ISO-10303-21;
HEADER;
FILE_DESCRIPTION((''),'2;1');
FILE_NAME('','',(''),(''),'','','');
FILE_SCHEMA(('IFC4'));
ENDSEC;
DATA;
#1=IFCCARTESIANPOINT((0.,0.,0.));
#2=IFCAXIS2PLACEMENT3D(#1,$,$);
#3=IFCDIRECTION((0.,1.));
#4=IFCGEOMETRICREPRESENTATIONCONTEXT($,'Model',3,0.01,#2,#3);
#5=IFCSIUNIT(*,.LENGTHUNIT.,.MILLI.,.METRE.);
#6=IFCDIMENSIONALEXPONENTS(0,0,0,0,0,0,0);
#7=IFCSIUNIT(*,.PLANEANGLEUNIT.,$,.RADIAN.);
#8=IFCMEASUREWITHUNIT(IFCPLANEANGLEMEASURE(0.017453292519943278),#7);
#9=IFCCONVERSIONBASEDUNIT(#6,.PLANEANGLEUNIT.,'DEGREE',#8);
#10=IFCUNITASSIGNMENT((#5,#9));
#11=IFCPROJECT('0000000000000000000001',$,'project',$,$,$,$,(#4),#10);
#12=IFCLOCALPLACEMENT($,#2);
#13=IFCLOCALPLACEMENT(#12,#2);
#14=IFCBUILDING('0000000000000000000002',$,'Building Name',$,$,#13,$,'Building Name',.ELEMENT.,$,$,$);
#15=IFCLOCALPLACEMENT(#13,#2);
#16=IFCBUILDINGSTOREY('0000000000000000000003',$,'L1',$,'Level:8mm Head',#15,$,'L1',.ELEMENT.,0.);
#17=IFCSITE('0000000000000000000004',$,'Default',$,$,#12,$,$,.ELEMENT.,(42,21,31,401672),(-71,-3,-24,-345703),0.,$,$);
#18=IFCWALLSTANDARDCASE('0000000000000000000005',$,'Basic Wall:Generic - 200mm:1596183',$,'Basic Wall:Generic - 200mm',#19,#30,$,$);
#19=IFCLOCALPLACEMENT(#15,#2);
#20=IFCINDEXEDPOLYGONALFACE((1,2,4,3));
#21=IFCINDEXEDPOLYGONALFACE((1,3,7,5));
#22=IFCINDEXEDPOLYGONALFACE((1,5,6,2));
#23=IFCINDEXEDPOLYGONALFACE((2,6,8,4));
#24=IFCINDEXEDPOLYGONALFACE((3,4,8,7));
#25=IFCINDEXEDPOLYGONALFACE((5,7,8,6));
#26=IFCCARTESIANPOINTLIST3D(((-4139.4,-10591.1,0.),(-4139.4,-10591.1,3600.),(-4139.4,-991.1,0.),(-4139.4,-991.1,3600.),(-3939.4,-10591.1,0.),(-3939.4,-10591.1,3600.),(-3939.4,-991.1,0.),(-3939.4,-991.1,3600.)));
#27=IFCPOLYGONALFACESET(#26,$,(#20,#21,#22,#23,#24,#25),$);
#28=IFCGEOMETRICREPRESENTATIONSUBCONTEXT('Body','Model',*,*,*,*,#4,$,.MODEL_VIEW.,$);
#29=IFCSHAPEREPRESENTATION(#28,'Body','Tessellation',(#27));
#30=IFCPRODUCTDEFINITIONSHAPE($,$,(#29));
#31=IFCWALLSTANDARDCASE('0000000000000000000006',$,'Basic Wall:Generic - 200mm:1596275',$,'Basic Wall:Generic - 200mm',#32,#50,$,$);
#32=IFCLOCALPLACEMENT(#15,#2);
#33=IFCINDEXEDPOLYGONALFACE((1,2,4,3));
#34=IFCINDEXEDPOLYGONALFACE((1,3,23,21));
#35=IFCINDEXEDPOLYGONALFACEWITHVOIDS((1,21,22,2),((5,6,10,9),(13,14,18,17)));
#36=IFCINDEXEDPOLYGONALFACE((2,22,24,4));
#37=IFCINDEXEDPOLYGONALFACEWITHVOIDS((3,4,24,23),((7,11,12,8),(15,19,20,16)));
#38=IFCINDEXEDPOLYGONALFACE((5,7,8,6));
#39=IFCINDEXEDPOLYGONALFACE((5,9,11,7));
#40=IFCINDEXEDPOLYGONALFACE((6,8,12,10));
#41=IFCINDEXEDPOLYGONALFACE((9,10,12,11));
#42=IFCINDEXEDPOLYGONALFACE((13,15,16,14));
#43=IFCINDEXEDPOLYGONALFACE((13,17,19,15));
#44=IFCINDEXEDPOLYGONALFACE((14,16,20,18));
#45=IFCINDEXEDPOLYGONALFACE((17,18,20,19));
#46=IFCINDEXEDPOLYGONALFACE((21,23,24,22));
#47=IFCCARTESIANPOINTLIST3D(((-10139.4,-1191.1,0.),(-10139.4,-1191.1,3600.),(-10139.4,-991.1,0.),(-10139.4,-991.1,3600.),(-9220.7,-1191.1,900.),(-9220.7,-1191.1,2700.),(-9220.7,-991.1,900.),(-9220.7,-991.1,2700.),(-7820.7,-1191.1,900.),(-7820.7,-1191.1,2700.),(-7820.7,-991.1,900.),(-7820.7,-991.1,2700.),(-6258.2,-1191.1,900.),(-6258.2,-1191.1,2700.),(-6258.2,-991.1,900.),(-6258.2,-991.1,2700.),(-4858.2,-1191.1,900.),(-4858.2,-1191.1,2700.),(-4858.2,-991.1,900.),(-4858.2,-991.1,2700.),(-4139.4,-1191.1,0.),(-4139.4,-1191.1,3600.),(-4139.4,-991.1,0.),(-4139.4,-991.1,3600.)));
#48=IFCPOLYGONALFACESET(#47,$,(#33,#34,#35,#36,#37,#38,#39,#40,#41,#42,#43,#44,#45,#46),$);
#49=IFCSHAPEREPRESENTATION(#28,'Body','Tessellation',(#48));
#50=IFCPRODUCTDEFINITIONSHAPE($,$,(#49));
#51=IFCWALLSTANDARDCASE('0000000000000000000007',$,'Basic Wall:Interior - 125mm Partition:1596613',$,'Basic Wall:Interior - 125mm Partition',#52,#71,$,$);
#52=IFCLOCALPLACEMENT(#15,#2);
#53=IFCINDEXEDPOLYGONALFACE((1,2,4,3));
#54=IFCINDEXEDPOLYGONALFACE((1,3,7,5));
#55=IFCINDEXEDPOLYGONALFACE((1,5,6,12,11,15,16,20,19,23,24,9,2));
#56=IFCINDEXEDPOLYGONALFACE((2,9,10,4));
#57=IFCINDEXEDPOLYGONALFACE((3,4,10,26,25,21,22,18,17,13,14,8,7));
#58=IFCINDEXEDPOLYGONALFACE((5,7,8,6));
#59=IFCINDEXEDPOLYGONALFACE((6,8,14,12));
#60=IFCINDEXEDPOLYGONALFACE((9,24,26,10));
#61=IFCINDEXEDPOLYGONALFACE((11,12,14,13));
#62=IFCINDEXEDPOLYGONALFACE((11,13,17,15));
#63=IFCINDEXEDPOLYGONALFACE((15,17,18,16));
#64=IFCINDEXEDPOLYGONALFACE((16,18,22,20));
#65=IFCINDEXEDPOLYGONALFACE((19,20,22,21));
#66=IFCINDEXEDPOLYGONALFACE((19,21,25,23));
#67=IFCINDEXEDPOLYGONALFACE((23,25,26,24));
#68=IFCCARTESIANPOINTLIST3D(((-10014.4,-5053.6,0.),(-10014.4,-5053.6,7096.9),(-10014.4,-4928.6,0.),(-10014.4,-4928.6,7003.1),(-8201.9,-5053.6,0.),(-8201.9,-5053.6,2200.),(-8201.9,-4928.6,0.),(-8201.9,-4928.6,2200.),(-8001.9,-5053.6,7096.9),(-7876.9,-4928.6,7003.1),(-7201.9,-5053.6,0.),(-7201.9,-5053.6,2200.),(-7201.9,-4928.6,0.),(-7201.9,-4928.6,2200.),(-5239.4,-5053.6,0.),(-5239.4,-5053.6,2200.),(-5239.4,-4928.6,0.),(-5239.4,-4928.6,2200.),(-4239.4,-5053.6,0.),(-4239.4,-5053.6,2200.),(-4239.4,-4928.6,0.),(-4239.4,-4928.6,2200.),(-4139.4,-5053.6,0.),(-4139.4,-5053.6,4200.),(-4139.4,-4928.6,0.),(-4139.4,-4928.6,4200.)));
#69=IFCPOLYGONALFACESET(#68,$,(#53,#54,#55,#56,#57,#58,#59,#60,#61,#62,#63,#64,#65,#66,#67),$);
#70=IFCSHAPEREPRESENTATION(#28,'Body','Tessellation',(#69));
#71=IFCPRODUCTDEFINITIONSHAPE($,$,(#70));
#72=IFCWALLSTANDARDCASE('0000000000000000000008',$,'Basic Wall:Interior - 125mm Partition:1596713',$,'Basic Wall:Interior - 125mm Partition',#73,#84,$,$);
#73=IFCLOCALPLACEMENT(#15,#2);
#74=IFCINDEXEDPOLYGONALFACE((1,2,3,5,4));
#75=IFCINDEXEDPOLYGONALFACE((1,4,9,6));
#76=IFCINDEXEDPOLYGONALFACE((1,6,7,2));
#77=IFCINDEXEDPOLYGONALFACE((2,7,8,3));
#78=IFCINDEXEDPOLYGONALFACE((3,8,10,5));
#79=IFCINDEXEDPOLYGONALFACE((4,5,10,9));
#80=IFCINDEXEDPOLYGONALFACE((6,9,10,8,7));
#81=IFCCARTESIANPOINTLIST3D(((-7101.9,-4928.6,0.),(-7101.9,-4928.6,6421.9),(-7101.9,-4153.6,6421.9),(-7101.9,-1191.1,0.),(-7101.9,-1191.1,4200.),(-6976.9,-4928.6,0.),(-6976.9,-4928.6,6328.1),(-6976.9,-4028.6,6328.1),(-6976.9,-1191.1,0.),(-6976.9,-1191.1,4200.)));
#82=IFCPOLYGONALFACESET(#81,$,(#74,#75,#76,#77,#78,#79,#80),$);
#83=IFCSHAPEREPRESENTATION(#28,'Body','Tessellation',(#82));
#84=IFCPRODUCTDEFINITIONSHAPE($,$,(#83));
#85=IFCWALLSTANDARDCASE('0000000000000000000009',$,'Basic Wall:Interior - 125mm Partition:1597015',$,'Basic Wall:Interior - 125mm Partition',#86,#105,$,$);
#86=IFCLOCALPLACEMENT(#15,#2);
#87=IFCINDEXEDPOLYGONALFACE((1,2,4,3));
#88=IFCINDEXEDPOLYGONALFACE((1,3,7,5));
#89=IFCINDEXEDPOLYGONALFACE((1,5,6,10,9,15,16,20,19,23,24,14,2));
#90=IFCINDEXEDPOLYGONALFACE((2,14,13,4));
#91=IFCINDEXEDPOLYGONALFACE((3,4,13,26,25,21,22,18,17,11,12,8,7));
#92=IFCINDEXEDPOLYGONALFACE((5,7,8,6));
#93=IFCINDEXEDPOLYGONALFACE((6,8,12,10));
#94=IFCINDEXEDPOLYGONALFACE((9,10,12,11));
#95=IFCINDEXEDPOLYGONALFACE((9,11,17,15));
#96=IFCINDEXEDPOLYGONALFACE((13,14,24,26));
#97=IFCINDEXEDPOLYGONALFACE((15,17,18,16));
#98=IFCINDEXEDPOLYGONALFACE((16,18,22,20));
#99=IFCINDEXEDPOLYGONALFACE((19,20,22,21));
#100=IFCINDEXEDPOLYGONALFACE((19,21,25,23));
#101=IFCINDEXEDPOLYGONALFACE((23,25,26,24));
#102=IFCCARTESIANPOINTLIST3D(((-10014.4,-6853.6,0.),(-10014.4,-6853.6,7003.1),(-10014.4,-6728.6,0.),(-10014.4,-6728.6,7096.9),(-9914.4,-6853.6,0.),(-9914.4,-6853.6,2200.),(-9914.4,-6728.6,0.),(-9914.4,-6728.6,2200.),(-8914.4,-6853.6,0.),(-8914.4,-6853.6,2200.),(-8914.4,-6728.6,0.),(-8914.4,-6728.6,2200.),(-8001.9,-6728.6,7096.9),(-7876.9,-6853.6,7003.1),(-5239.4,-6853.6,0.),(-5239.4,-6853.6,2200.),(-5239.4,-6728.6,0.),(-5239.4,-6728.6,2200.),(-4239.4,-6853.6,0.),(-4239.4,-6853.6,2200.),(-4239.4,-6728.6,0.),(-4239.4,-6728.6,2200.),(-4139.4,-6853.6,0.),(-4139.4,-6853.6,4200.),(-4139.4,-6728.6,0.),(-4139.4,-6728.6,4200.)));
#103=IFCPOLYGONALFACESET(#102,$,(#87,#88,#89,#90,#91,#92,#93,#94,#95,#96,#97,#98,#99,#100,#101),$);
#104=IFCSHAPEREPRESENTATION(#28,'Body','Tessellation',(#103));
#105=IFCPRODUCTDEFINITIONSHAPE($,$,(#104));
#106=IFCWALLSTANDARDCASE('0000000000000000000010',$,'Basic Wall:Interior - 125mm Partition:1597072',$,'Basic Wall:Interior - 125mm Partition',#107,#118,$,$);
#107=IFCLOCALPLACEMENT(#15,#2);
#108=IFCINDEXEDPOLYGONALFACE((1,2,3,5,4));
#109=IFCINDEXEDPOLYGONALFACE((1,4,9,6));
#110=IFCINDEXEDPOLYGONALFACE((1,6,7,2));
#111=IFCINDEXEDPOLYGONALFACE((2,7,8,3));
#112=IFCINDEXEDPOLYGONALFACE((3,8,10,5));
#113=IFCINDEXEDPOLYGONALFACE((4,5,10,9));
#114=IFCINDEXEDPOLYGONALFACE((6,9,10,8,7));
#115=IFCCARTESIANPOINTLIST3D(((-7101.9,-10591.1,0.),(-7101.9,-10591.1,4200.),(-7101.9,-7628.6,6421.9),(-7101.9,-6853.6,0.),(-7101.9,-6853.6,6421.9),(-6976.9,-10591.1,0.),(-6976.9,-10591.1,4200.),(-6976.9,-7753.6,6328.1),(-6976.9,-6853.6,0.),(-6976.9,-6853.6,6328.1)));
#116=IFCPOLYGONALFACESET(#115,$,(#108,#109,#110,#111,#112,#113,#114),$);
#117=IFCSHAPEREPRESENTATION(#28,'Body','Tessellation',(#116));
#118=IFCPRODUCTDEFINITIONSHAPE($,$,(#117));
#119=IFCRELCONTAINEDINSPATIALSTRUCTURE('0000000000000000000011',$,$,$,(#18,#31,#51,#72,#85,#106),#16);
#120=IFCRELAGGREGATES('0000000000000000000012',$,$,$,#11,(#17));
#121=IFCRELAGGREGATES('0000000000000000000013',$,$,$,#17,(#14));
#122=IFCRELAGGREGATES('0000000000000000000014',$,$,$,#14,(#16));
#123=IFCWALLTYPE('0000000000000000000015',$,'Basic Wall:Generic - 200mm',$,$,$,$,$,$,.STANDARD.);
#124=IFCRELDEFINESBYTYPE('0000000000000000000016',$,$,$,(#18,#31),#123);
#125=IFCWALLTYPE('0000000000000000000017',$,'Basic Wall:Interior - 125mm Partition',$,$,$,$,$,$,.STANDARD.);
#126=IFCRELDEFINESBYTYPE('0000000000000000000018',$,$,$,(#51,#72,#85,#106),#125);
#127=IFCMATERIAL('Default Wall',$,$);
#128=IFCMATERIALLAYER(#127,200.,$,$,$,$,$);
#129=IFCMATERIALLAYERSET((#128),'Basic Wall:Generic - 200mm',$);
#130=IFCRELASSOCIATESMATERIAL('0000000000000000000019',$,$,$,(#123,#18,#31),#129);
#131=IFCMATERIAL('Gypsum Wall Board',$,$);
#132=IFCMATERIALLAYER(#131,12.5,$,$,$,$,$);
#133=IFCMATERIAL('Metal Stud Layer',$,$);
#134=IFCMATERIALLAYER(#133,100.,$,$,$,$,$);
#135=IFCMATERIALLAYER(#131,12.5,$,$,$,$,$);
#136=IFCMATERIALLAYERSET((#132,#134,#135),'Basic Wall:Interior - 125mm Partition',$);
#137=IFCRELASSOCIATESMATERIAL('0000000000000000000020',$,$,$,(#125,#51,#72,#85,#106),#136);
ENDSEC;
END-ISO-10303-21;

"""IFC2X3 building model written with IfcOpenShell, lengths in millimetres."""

from ifc_helpers import new_model, entity, si_unit, converted_unit, direction, frame, frame_2d, origin, place, context, subcontext, project, spatial, polyline, rectangle, extrude, clip, bounded_halfspace, material, layer, layer_set, layer_usage, type_object, element, save


model = new_model("IFC2X3")

# Units and contexts
model_context = context("Model", 3, precision=0.01, world=origin(), true_north=direction((0.0, 1.0)))
body_context = subcontext(model_context, "Body", "Model", "MODEL_VIEW")
ifc_project = project(units=[si_unit("LENGTHUNIT", "METRE", prefix="MILLI"), converted_unit("PLANEANGLEUNIT", "DEGREE", entity("IfcPlaneAngleMeasure", 0.017453292519943278), si_unit("PLANEANGLEUNIT", "RADIAN"), dimensions=[0, 0, 0, 0, 0, 0, 0])], contexts=[model_context])

# Site, building, storey
site_placement = place(None, origin())
site = spatial("IfcSite", under=ifc_project, at=site_placement, Name="Default", CompositionType="ELEMENT", RefLatitude=(42, 21, 31, 401672), RefLongitude=(-71, -3, -24, -345703), RefElevation=0.0)
building_placement = place(site_placement, origin())
building = spatial("IfcBuilding", under=site, at=building_placement, Name="Building Name", LongName="Building Name", CompositionType="ELEMENT")
storey_placement = place(building_placement, origin())
storey = spatial("IfcBuildingStorey", under=building, at=storey_placement, Name="L1", ObjectType="Level:8mm Head", LongName="L1", CompositionType="ELEMENT", Elevation=0.0)

# Wall
ifc_material_1 = material(Name="Default Wall")
ifc_layer_1 = layer(ifc_material_1, 200.0)
ifc_layer_set_1 = layer_set([ifc_layer_1], Name="Basic Wall:Generic - 200mm")
ifc_layer_usage_1 = layer_usage(ifc_layer_set_1, "AXIS2", "NEGATIVE", 100.0)
wall_type_1 = type_object("IfcWallType", Name="Basic Wall:Generic - 200mm", PredefinedType="STANDARD", material=ifc_layer_set_1)
wall_1_placement = place(storey_placement, frame((-4039.4, -10591.1, 0.0), z_axis=(0.0, 0.0, 1.0), x_axis=(0.0, 1.0, 0.0)))
element("IfcWallStandardCase", 1, at=wall_1_placement, inside=storey, type_object=wall_type_1, material=ifc_layer_usage_1, Name="Basic Wall:Generic - 200mm:1596183", ObjectType="Basic Wall:Generic - 200mm", context=body_context, shape_type="SweptSolid", body=[
    extrude(rectangle(XDim=9600.0, YDim=200.0, at=frame_2d((4800.0, 0.0), x_axis=(-1.0, 0.0))), origin(), (0.0, 0.0, 1.0), 3600.0),
])

# Walls, openings
wall_2_placement = place(storey_placement, frame((-4139.4, -1091.1, 0.0), z_axis=(0.0, 0.0, 1.0), x_axis=(-1.0, 0.0, 0.0)))
wall_2 = element("IfcWallStandardCase", 2, at=wall_2_placement, inside=storey, type_object=wall_type_1, material=ifc_layer_usage_1, Name="Basic Wall:Generic - 200mm:1596275", ObjectType="Basic Wall:Generic - 200mm", context=body_context, shape_type="SweptSolid", body=[
    extrude(rectangle(XDim=6000.0, YDim=200.0, at=frame_2d((3000.0, 0.0), x_axis=(-1.0, 0.0))), origin(), (0.0, 0.0, 1.0), 3600.0),
])
opening_1_placement = place(wall_2_placement, frame((2118.8, 100.0, 900.0)))
element("IfcOpeningElement", 3, at=opening_1_placement, cuts=wall_2, ObjectType="Opening", context=body_context, shape_type="SweptSolid", body=[
    extrude(rectangle(XDim=1800.0, YDim=1400.0, at=frame_2d((900.0, 700.0), x_axis=(-1.0, 0.0))), frame((0.0, 0.0, 0.0), z_axis=(0.0, -1.0, 0.0), x_axis=(0.0, 0.0, 1.0)), (0.0, 0.0, 1.0), 200.0),
])
opening_2_placement = place(wall_2_placement, frame((5081.3, 100.0, 900.0)))
element("IfcOpeningElement", 4, at=opening_2_placement, cuts=wall_2, ObjectType="Opening", context=body_context, shape_type="SweptSolid", body=[
    extrude(rectangle(XDim=1800.0, YDim=1400.0, at=frame_2d((900.0, 700.0), x_axis=(-1.0, 0.0))), frame((0.0, 0.0, 0.0), z_axis=(0.0, -1.0, 0.0), x_axis=(0.0, 0.0, 1.0)), (0.0, 0.0, 1.0), 200.0),
])
ifc_material_2 = material(Name="Gypsum Wall Board")
ifc_layer_2 = layer(ifc_material_2, 12.5)
ifc_material_3 = material(Name="Metal Stud Layer")
ifc_layer_3 = layer(ifc_material_3, 100.0)
ifc_layer_4 = layer(ifc_material_2, 12.5)
ifc_layer_set_2 = layer_set([ifc_layer_2, ifc_layer_3, ifc_layer_4], Name="Basic Wall:Interior - 125mm Partition")
ifc_layer_usage_2 = layer_usage(ifc_layer_set_2, "AXIS2", "NEGATIVE", 62.5)
wall_type_2 = type_object("IfcWallType", Name="Basic Wall:Interior - 125mm Partition", PredefinedType="STANDARD", material=ifc_layer_set_2)
wall_3_placement = place(storey_placement, frame((-10014.4, -4991.1, 0.0)))
wall_3 = element("IfcWallStandardCase", 5, at=wall_3_placement, inside=storey, type_object=wall_type_2, material=ifc_layer_usage_2, Name="Basic Wall:Interior - 125mm Partition:1596613", ObjectType="Basic Wall:Interior - 125mm Partition", context=body_context, shape_type="Clipping", body=[
    clip(clip(extrude(rectangle(XDim=5875.0, YDim=125.0, at=frame_2d((2937.5, 0.0), x_axis=(-1.0, 0.0))), origin(), (0.0, 0.0, 1.0), 7096.9), bounded_halfspace(frame((5875.0, -62.5, 4200.0), z_axis=(0.6, 0.0, 0.8), x_axis=(0.0, 1.0, 0.0)), False, frame((5875.0, -62.5, 4200.0)), polyline([(0.0, 0.0), (0.0, 125.0), (-2837.5, 125.0), (-2962.5, 125.0), (-3737.5, 125.0), (-3862.5, 0.0), (0.0, 0.0)]))), bounded_halfspace(frame((0.0, 62.5, 7003.1), z_axis=(0.0, 0.6, 0.8), x_axis=(-1.0, 0.0, 0.0)), False, frame((0.0, 62.5, 7003.1)), polyline([(0.0, 0.0), (0.0, -125.0), (2012.5, -125.0), (2137.5, 0.0), (0.0, 0.0)]))),
])
opening_3_placement = place(wall_3_placement, frame((1812.5, -62.5, 0.0)))
element("IfcOpeningElement", 6, at=opening_3_placement, cuts=wall_3, ObjectType="Opening", context=body_context, shape_type="SweptSolid", body=[
    extrude(rectangle(XDim=2200.0, YDim=1000.0, at=frame_2d((1100.0, 500.0), x_axis=(1.0, 0.0))), frame((0.0, 0.0, 0.0), z_axis=(0.0, 1.0, 0.0), x_axis=(0.0, 0.0, 1.0)), (0.0, 0.0, 1.0), 125.0),
])
opening_4_placement = place(wall_3_placement, frame((4775.0, -62.5, 0.0)))
element("IfcOpeningElement", 7, at=opening_4_placement, cuts=wall_3, ObjectType="Opening", context=body_context, shape_type="SweptSolid", body=[
    extrude(rectangle(XDim=2200.0, YDim=1000.0, at=frame_2d((1100.0, 500.0), x_axis=(1.0, 0.0))), frame((0.0, 0.0, 0.0), z_axis=(0.0, 1.0, 0.0), x_axis=(0.0, 0.0, 1.0)), (0.0, 0.0, 1.0), 125.0),
])

# Wall
wall_4_placement = place(storey_placement, frame((-7039.4, -4928.6, 0.0), z_axis=(0.0, 0.0, 1.0), x_axis=(0.0, 1.0, 0.0)))
element("IfcWallStandardCase", 8, at=wall_4_placement, inside=storey, type_object=wall_type_2, material=ifc_layer_usage_2, Name="Basic Wall:Interior - 125mm Partition:1596713", ObjectType="Basic Wall:Interior - 125mm Partition", context=body_context, shape_type="Clipping", body=[
    clip(clip(extrude(rectangle(XDim=3737.5, YDim=125.0, at=frame_2d((1868.8, 0.0), x_axis=(-1.0, 0.0))), origin(), (0.0, 0.0, 1.0), 6421.9), bounded_halfspace(frame((0.0, -62.5, 6328.1), z_axis=(0.0, -0.6, 0.8), x_axis=(1.0, 0.0, 0.0)), False, frame((0.0, -62.5, 6328.1)), polyline([(0.0, 0.0), (900.0, 0.0), (775.0, 125.0), (0.0, 125.0), (0.0, 0.0)]))), bounded_halfspace(frame((900.0, -62.5, 6328.1), z_axis=(0.6, 0.0, 0.8), x_axis=(0.0, 1.0, 0.0)), False, frame((900.0, -62.5, 6328.1)), polyline([(0.0, 0.0), (2837.5, 0.0), (2837.5, 125.0), (-125.0, 125.0), (0.0, 0.0)]))),
])

# Wall, openings
wall_5_placement = place(storey_placement, frame((-10014.4, -6791.1, 0.0)))
wall_5 = element("IfcWallStandardCase", 9, at=wall_5_placement, inside=storey, type_object=wall_type_2, material=ifc_layer_usage_2, Name="Basic Wall:Interior - 125mm Partition:1597015", ObjectType="Basic Wall:Interior - 125mm Partition", context=body_context, shape_type="Clipping", body=[
    clip(clip(extrude(rectangle(XDim=5875.0, YDim=125.0, at=frame_2d((2937.5, 0.0), x_axis=(-1.0, 0.0))), origin(), (0.0, 0.0, 1.0), 7096.9), bounded_halfspace(frame((0.0, 62.5, 7096.9), z_axis=(0.0, -0.6, 0.8), x_axis=(1.0, 0.0, 0.0)), False, frame((0.0, 62.5, 7096.9)), polyline([(0.0, 0.0), (0.0, -125.0), (2137.5, -125.0), (2012.5, 0.0), (0.0, 0.0)]))), bounded_halfspace(frame((5875.0, -62.5, 4200.0), z_axis=(0.6, 0.0, 0.8), x_axis=(0.0, 1.0, 0.0)), False, frame((5875.0, -62.5, 4200.0)), polyline([(0.0, 0.0), (0.0, 125.0), (-3862.5, 125.0), (-3737.5, 0.0), (-2962.5, 0.0), (-2837.5, 0.0), (0.0, 0.0)]))),
])
opening_5_placement = place(wall_5_placement, frame((5775.0, 62.5, 0.0)))
element("IfcOpeningElement", 10, at=opening_5_placement, cuts=wall_5, ObjectType="Opening", context=body_context, shape_type="SweptSolid", body=[
    extrude(rectangle(XDim=2200.0, YDim=1000.0, at=frame_2d((1100.0, 500.0), x_axis=(1.0, 0.0))), frame((0.0, 0.0, 0.0), z_axis=(0.0, -1.0, 0.0), x_axis=(0.0, 0.0, 1.0)), (0.0, 0.0, 1.0), 125.0),
])
opening_6_placement = place(wall_5_placement, frame((1100.0, 62.5, 0.0)))
element("IfcOpeningElement", 11, at=opening_6_placement, cuts=wall_5, ObjectType="Opening", context=body_context, shape_type="SweptSolid", body=[
    extrude(rectangle(XDim=2200.0, YDim=1000.0, at=frame_2d((1100.0, 500.0), x_axis=(1.0, 0.0))), frame((0.0, 0.0, 0.0), z_axis=(0.0, -1.0, 0.0), x_axis=(0.0, 0.0, 1.0)), (0.0, 0.0, 1.0), 125.0),
])

# Wall
wall_6_placement = place(storey_placement, frame((-7039.4, -6853.6, 0.0), z_axis=(0.0, 0.0, 1.0), x_axis=(0.0, -1.0, 0.0)))
element("IfcWallStandardCase", 12, at=wall_6_placement, inside=storey, type_object=wall_type_2, material=ifc_layer_usage_2, Name="Basic Wall:Interior - 125mm Partition:1597072", ObjectType="Basic Wall:Interior - 125mm Partition", context=body_context, shape_type="Clipping", body=[
    clip(clip(extrude(rectangle(XDim=3737.5, YDim=125.0, at=frame_2d((1868.8, 0.0), x_axis=(-1.0, 0.0))), origin(), (0.0, 0.0, 1.0), 6421.9), bounded_halfspace(frame((775.0, -62.5, 6421.9), z_axis=(0.6, 0.0, 0.8), x_axis=(0.0, 1.0, 0.0)), False, frame((775.0, -62.5, 6421.9)), polyline([(0.0, 0.0), (2962.5, 0.0), (2962.5, 125.0), (125.0, 125.0), (0.0, 0.0)]))), bounded_halfspace(frame((0.0, -62.5, 6421.9), z_axis=(0.0, 0.6, 0.8), x_axis=(-1.0, 0.0, 0.0)), False, frame((0.0, -62.5, 6421.9)), polyline([(0.0, 0.0), (775.0, 0.0), (900.0, 125.0), (0.0, 125.0), (0.0, 0.0)]))),
])

save(model, "model.ifc")
